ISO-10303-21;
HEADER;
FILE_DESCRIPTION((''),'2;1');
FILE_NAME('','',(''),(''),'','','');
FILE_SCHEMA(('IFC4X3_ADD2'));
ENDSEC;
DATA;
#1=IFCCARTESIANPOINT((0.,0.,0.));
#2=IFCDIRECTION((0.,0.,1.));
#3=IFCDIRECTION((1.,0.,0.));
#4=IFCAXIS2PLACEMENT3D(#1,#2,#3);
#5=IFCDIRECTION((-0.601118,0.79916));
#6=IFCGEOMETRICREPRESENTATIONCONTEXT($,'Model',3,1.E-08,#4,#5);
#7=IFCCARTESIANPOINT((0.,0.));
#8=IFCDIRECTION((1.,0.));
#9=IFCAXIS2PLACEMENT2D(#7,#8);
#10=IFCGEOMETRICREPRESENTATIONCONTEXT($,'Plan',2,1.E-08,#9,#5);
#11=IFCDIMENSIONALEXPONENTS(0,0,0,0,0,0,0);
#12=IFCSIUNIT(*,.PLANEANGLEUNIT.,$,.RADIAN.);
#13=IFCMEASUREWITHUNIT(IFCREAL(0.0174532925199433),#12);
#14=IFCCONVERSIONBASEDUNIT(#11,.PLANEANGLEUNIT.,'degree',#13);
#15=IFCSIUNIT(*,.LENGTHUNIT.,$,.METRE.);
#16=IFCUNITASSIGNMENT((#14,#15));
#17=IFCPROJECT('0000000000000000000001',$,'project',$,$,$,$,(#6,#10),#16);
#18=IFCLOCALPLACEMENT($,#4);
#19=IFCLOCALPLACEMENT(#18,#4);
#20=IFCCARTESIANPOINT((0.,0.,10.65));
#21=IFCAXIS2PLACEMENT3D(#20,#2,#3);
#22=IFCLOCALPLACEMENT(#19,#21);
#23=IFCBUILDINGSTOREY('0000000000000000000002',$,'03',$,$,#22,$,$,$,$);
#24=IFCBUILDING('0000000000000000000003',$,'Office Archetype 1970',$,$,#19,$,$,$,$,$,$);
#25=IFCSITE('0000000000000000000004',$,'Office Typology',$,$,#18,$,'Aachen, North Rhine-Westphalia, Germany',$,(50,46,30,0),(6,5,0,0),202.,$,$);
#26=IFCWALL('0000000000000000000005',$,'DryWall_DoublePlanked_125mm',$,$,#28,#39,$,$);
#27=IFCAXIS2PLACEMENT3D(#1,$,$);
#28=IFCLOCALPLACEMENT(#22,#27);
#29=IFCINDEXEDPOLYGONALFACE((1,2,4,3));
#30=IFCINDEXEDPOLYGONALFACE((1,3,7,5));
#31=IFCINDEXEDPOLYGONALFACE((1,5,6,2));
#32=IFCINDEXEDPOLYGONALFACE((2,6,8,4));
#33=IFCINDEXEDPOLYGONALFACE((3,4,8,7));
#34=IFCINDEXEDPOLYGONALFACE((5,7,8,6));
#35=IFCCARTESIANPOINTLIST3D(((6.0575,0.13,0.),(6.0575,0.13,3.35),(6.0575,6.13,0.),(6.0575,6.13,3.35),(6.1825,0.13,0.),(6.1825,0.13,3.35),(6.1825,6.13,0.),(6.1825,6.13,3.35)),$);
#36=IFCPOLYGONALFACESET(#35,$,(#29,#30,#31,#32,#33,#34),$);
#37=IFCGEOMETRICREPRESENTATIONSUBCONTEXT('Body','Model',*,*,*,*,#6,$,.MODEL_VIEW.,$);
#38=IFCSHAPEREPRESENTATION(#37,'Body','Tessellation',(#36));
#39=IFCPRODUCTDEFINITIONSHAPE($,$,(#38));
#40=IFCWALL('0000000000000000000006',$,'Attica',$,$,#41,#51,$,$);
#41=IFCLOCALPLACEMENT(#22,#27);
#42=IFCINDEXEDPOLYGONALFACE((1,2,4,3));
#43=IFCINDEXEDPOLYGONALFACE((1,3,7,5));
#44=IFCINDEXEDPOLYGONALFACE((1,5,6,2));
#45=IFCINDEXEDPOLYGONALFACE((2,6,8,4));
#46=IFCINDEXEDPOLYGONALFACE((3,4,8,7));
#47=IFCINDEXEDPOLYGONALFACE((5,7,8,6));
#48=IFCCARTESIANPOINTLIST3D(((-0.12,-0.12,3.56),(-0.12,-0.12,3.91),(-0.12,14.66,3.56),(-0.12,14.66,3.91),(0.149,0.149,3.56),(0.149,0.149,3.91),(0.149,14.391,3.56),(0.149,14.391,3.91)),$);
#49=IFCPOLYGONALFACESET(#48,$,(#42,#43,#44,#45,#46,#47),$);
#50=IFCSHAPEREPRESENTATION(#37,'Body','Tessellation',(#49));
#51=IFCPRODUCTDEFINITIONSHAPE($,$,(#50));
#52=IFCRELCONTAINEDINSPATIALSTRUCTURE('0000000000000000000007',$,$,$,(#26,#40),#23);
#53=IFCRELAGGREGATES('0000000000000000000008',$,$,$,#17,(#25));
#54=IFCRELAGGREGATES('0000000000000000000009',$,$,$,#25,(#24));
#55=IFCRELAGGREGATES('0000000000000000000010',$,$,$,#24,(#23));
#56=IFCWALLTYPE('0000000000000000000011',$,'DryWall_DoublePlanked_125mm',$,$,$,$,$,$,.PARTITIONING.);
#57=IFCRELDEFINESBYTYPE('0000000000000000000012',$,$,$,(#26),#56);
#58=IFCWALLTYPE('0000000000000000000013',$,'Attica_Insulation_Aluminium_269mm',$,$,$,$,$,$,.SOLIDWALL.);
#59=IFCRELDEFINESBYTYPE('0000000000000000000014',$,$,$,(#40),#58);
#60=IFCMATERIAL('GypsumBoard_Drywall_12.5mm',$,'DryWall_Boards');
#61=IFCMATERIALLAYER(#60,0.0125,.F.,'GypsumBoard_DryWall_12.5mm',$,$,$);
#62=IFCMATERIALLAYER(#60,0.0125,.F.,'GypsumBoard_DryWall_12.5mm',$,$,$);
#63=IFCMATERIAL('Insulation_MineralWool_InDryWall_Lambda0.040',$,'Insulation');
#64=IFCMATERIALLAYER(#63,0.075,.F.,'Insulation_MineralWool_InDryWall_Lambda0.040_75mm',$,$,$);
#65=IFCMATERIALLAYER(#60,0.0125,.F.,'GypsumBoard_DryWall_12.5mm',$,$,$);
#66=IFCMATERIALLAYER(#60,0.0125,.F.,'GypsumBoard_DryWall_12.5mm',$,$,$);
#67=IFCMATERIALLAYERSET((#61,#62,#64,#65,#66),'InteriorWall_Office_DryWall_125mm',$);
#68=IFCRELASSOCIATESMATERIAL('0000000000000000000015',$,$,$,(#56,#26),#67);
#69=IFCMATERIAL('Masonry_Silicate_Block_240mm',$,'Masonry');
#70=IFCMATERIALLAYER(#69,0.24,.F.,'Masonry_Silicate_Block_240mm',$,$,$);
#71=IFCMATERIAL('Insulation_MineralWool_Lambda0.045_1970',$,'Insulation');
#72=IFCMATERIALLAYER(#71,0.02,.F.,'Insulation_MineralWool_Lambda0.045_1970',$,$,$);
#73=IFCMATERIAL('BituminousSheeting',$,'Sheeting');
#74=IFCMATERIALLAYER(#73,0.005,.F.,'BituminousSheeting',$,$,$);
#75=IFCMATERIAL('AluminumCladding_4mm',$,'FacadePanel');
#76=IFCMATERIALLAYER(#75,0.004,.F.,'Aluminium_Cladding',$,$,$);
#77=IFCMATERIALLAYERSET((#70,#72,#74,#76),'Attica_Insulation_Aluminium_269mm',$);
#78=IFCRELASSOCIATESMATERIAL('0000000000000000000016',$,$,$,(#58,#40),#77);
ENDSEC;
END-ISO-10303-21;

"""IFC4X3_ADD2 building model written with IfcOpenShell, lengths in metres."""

from ifc_helpers import new_model, entity, si_unit, converted_unit, direction, frame, origin_with_axes, origin_2d_with_axis, place, context, subcontext, project, spatial, line, indexed_curve, outline, extrude, material, layer, layer_set, layer_usage, type_object, element, save


model = new_model("IFC4X3_ADD2")

# Units and contexts
model_context = context("Model", 3, precision=1e-08, world=origin_with_axes(), true_north=direction((-0.601118, 0.79916)))
plan_context = context("Plan", 2, precision=1e-08, world=origin_2d_with_axis(), true_north=direction((-0.601118, 0.79916)))
body_context = subcontext(model_context, "Body", "Model", "MODEL_VIEW")
ifc_project = project(units=[converted_unit("PLANEANGLEUNIT", "degree", entity("IfcReal", 0.0174532925199433), si_unit("PLANEANGLEUNIT", "RADIAN"), dimensions=[0, 0, 0, 0, 0, 0, 0]), si_unit("LENGTHUNIT", "METRE")], contexts=[model_context, plan_context])

# Site, building, storey
site_placement = place(None, origin_with_axes())
site = spatial("IfcSite", under=ifc_project, at=site_placement, Name="Office Typology", LongName="Aachen, North Rhine-Westphalia, Germany", RefLatitude=(50, 46, 30, 0), RefLongitude=(6, 5, 0, 0), RefElevation=202.0)
building_placement = place(site_placement, origin_with_axes())
building = spatial("IfcBuilding", under=site, at=building_placement, Name="Office Archetype 1970")
storey_placement = place(building_placement, frame((0.0, 0.0, 10.65), z_axis=(0.0, 0.0, 1.0), x_axis=(1.0, 0.0, 0.0)))
storey = spatial("IfcBuildingStorey", under=building, at=storey_placement, Name="03")

# Shared definitions
ifc_material_1 = material(Name="Masonry_Silicate_Block_240mm", Category="Masonry")

# Wall
ifc_material_2 = material(Name="GypsumBoard_Drywall_12.5mm", Category="DryWall_Boards")
ifc_layer_1 = layer(ifc_material_2, 0.0125, ventilated=False, Name="GypsumBoard_DryWall_12.5mm")
ifc_layer_2 = layer(ifc_material_2, 0.0125, ventilated=False, Name="GypsumBoard_DryWall_12.5mm")
ifc_material_3 = material(Name="Insulation_MineralWool_InDryWall_Lambda0.040", Category="Insulation")
ifc_layer_3 = layer(ifc_material_3, 0.075, ventilated=False, Name="Insulation_MineralWool_InDryWall_Lambda0.040_75mm")
ifc_layer_4 = layer(ifc_material_2, 0.0125, ventilated=False, Name="GypsumBoard_DryWall_12.5mm")
ifc_layer_5 = layer(ifc_material_2, 0.0125, ventilated=False, Name="GypsumBoard_DryWall_12.5mm")
ifc_layer_set_1 = layer_set([ifc_layer_1, ifc_layer_2, ifc_layer_3, ifc_layer_4, ifc_layer_5], Name="InteriorWall_Office_DryWall_125mm")
ifc_layer_usage_1 = layer_usage(ifc_layer_set_1, "AXIS2", "POSITIVE", 0.0)
wall_type_1 = type_object("IfcWallType", Name="DryWall_DoublePlanked_125mm", PredefinedType="PARTITIONING", material=ifc_layer_set_1)
wall_1_placement = place(storey_placement, frame((6.0575, 6.13, 0.0), z_axis=(0.0, 0.0, 1.0), x_axis=(0.0, -1.0, 0.0)))
element("IfcWall", 1, at=wall_1_placement, inside=storey, type_object=wall_type_1, material=ifc_layer_usage_1, Name="DryWall_DoublePlanked_125mm", context=body_context, shape_type="SweptSolid", body=[
    extrude(outline(indexed_curve([(0.0, 0.0), (0.0, 0.125), (6.0, 0.125), (6.0, 0.0)], segments=[line(1, 2, 3, 4, 1)])), origin_with_axes(), (0.0, 0.0, 1.0), 3.35),
])

# Shared definitions
ifc_material_4 = material(Name="Insulation_MineralWool_Lambda0.045_1970", Category="Insulation")

# Wall
ifc_layer_6 = layer(ifc_material_1, 0.24, ventilated=False, Name="Masonry_Silicate_Block_240mm")
ifc_layer_7 = layer(ifc_material_4, 0.02, ventilated=False, Name="Insulation_MineralWool_Lambda0.045_1970")
ifc_material_5 = material(Name="BituminousSheeting", Category="Sheeting")
ifc_layer_8 = layer(ifc_material_5, 0.005, ventilated=False, Name="BituminousSheeting")
ifc_material_6 = material(Name="AluminumCladding_4mm", Category="FacadePanel")
ifc_layer_9 = layer(ifc_material_6, 0.004, ventilated=False, Name="Aluminium_Cladding")
ifc_layer_set_2 = layer_set([ifc_layer_6, ifc_layer_7, ifc_layer_8, ifc_layer_9], Name="Attica_Insulation_Aluminium_269mm")
ifc_layer_usage_2 = layer_usage(ifc_layer_set_2, "AXIS2", "POSITIVE", 0.0)
wall_type_2 = type_object("IfcWallType", Name="Attica_Insulation_Aluminium_269mm", PredefinedType="SOLIDWALL", material=ifc_layer_set_2)
wall_2_placement = place(storey_placement, frame((-0.12, 14.66, 3.56), z_axis=(0.0, 0.0, 1.0), x_axis=(0.0, -1.0, 0.0)))
element("IfcWall", 2, at=wall_2_placement, inside=storey, type_object=wall_type_2, material=ifc_layer_usage_2, Name="Attica", context=body_context, shape_type="SweptSolid", body=[
    extrude(outline(indexed_curve([(0.0, 0.0), (0.269, 0.269), (14.511, 0.269), (14.78, 0.0)], segments=[line(1, 2, 3, 4, 1)])), origin_with_axes(), (0.0, 0.0, 1.0), 0.35),
])

save(model, "model.ifc")
